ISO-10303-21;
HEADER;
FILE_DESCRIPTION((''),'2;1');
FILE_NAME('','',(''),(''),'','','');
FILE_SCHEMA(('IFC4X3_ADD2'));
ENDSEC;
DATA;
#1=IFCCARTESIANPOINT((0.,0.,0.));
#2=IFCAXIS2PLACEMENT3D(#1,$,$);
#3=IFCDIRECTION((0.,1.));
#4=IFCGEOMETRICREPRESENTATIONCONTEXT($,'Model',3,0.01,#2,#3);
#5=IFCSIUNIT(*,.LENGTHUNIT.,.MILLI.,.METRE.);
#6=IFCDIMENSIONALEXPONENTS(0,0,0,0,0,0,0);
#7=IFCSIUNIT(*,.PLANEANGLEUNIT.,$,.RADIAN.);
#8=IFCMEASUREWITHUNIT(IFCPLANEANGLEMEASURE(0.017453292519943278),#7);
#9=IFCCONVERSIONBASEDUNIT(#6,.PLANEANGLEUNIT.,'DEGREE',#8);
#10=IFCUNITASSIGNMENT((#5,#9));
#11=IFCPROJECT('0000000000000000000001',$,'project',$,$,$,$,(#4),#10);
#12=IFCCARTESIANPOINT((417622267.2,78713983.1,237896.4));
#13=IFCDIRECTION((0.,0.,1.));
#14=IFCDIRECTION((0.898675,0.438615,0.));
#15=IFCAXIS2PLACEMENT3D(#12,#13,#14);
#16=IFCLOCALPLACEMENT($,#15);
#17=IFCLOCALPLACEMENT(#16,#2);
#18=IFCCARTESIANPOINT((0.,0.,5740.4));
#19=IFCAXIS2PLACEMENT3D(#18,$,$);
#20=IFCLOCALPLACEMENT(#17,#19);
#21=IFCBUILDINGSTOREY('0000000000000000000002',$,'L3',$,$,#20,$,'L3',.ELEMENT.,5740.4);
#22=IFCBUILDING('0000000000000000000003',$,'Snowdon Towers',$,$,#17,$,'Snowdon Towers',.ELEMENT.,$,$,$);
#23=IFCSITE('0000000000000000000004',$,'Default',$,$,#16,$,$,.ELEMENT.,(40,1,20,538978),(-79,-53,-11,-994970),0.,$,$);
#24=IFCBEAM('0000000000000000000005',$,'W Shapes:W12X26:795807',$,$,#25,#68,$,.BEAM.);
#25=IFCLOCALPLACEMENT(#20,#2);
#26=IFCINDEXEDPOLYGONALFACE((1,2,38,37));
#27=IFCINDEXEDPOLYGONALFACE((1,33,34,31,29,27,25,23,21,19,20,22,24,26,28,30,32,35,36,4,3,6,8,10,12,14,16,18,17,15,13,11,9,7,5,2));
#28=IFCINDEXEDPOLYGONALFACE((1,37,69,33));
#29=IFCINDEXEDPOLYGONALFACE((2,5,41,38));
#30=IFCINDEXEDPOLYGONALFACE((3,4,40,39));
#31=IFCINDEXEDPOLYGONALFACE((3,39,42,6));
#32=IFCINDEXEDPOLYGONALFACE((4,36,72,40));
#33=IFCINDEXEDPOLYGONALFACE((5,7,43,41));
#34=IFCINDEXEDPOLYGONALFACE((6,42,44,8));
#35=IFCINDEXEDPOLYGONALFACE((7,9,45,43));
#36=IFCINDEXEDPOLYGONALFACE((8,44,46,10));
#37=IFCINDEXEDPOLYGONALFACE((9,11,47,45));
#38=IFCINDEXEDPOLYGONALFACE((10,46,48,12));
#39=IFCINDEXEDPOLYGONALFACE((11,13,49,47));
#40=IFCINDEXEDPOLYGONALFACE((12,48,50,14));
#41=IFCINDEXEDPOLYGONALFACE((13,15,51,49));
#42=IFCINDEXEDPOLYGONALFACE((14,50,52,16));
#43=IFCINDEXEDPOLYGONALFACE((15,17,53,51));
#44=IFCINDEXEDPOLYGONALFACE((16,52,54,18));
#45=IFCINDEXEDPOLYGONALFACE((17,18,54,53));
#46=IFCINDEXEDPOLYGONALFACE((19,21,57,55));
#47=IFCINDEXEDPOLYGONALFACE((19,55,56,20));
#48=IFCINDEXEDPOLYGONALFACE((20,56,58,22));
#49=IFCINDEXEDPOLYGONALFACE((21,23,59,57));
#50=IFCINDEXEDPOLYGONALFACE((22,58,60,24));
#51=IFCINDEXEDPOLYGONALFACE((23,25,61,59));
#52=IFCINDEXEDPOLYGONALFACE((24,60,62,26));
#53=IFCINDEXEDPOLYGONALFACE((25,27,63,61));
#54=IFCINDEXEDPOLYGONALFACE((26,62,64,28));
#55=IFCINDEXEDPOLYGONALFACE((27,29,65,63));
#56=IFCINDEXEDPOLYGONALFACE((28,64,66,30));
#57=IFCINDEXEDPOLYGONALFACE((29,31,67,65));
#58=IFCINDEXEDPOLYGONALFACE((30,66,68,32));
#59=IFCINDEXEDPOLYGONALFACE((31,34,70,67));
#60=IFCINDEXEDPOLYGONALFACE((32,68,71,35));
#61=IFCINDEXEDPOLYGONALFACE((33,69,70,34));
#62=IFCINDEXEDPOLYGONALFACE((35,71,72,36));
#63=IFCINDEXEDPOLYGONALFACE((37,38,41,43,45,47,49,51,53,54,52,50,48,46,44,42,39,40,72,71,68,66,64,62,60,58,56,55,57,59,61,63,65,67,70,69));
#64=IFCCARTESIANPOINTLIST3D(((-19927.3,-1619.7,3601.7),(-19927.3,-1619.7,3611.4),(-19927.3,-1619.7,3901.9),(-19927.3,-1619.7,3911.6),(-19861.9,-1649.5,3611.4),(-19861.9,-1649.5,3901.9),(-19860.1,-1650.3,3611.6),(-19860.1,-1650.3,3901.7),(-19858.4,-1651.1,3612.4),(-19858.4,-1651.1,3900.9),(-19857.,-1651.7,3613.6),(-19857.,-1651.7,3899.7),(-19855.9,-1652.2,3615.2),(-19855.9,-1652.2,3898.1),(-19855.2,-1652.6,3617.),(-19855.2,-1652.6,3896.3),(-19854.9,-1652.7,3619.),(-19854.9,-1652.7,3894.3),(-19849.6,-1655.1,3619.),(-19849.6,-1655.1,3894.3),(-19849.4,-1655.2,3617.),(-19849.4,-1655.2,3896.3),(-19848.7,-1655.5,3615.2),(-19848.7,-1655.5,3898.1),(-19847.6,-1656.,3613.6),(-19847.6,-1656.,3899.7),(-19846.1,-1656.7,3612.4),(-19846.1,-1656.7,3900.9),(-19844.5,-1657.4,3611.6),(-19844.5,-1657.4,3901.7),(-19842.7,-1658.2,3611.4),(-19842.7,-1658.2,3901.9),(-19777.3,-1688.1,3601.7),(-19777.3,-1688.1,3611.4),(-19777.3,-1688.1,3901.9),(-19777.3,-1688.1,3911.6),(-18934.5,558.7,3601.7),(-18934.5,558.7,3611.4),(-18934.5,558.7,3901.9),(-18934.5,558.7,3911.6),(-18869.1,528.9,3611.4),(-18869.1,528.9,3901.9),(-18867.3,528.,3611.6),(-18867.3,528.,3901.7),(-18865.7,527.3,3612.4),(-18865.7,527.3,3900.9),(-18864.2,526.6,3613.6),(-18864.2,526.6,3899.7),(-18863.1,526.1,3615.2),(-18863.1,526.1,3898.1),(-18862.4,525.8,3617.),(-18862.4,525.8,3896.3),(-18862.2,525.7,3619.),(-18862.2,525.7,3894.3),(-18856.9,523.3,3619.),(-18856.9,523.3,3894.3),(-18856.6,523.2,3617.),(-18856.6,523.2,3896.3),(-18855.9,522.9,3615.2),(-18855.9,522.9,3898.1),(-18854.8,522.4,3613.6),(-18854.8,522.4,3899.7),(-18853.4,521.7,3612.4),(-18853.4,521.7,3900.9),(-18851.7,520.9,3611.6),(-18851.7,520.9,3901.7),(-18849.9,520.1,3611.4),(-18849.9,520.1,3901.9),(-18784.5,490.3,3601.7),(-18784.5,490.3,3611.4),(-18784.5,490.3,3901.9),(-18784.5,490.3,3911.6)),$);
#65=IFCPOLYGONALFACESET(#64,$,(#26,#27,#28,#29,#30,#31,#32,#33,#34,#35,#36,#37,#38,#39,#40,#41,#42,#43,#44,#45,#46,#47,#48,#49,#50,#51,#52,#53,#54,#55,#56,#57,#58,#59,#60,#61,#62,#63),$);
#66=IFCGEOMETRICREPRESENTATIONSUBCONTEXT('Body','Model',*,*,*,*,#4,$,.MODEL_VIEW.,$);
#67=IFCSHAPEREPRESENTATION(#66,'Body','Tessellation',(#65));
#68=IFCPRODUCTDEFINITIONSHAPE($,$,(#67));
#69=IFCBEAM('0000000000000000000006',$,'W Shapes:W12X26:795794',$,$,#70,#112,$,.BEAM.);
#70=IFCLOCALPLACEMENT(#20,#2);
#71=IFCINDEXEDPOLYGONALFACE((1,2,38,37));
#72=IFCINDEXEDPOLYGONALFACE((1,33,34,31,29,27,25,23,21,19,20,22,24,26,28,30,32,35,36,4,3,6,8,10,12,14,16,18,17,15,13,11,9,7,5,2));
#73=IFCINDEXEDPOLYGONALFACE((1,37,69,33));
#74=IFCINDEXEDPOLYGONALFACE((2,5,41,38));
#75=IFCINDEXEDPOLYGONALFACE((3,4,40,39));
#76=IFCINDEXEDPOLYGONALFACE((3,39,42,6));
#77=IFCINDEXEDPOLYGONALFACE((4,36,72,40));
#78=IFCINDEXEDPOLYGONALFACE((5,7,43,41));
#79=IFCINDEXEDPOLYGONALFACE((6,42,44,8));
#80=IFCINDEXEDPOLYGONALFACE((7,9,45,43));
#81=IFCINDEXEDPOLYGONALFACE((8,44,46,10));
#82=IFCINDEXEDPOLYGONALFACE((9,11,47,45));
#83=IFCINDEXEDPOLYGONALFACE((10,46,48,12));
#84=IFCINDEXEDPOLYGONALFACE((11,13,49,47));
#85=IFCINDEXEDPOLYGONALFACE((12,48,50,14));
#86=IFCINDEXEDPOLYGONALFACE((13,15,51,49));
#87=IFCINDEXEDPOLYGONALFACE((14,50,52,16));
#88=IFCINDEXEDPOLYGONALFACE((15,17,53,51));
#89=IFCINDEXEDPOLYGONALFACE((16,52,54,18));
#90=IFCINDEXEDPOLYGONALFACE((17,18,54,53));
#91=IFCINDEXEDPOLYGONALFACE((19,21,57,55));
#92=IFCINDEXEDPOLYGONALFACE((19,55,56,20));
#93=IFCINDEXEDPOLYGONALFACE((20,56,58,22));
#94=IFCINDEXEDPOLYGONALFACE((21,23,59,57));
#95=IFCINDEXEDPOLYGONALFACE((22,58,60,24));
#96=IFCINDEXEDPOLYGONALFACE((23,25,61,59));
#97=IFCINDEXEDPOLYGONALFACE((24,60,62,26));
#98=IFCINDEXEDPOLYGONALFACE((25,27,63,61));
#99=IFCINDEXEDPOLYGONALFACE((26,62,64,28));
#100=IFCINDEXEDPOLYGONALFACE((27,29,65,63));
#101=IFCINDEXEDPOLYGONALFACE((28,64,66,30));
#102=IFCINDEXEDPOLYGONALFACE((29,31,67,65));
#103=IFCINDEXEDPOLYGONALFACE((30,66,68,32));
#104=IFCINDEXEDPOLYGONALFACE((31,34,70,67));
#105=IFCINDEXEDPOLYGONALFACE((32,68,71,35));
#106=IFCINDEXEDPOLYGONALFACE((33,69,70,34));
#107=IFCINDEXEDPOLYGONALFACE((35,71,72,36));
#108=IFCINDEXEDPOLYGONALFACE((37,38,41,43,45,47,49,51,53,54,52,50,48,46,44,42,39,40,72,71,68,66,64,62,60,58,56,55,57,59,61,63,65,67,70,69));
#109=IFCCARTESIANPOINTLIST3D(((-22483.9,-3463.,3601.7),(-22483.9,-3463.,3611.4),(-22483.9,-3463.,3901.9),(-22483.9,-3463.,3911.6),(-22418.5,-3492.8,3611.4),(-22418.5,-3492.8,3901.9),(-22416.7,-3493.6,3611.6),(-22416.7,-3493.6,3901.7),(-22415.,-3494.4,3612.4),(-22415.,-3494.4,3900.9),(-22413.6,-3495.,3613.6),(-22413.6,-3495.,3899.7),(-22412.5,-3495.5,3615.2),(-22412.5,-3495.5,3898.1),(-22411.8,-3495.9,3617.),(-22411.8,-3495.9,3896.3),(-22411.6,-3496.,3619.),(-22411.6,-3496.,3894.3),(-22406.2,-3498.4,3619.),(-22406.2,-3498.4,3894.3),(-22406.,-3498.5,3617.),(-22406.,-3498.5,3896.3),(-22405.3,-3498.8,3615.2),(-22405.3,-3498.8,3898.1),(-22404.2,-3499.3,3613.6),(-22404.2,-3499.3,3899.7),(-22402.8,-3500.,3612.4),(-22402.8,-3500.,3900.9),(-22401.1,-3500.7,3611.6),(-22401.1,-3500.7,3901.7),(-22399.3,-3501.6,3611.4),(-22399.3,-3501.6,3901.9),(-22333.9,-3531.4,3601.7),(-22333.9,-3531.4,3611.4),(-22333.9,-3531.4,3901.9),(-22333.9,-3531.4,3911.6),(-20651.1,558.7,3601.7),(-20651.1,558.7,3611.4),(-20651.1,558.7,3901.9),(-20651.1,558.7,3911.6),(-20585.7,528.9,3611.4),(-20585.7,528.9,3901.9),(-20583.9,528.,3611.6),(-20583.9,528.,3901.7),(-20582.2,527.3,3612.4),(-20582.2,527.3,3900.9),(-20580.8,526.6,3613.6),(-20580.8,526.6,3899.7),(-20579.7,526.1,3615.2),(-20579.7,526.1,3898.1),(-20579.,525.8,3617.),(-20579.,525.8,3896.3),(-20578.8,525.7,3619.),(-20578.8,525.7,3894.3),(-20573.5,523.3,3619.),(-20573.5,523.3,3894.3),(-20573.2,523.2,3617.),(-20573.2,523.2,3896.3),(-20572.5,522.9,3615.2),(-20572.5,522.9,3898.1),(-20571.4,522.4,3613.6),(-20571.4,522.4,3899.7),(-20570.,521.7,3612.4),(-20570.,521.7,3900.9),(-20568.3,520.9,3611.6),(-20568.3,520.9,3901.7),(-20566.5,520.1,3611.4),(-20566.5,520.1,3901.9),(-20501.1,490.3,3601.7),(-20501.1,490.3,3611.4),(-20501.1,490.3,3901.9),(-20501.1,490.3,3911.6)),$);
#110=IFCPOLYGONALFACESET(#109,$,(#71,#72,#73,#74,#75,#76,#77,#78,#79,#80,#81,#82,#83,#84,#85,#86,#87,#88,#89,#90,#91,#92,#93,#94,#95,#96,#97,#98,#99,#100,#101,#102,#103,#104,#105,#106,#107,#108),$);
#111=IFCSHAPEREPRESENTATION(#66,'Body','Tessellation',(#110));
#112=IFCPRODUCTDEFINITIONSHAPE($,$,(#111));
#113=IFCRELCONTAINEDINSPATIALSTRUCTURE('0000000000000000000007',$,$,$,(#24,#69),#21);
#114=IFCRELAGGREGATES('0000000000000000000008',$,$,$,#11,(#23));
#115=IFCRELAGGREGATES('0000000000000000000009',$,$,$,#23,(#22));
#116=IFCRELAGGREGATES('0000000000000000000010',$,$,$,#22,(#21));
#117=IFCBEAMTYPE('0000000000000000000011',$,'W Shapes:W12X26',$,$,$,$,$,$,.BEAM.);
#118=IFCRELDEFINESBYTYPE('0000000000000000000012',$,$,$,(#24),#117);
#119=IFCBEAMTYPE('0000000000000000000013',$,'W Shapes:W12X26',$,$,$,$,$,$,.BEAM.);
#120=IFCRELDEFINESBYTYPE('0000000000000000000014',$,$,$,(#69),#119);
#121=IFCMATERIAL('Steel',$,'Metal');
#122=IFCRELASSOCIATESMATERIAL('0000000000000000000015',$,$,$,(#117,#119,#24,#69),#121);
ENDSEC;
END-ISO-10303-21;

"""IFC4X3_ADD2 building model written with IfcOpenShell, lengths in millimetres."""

from ifc_helpers import new_model, entity, si_unit, converted_unit, direction, frame, frame_2d, origin, place, context, subcontext, project, spatial, polyline, circle_curve, parameter, trimmed, segment, composite_curve, outline, extrude, source, transform, mapped, material, material_profile, profile_set, profile_usage, type_object, type_shapes, element, save


model = new_model("IFC4X3_ADD2")

# Units and contexts
model_context = context("Model", 3, precision=0.01, world=origin(), true_north=direction((0.0, 1.0)))
body_context = subcontext(model_context, "Body", "Model", "MODEL_VIEW")
ifc_project = project(units=[si_unit("LENGTHUNIT", "METRE", prefix="MILLI"), converted_unit("PLANEANGLEUNIT", "DEGREE", entity("IfcPlaneAngleMeasure", 0.017453292519943278), si_unit("PLANEANGLEUNIT", "RADIAN"), dimensions=[0, 0, 0, 0, 0, 0, 0])], contexts=[model_context])

# Site, building, storey
site_placement = place(None, frame((417622267.2, 78713983.1, 237896.4), z_axis=(0.0, 0.0, 1.0), x_axis=(0.898675, 0.438615, 0.0)))
site = spatial("IfcSite", under=ifc_project, at=site_placement, Name="Default", CompositionType="ELEMENT", RefLatitude=(40, 1, 20, 538978), RefLongitude=(-79, -53, -11, -994970), RefElevation=0.0)
building_placement = place(site_placement, origin())
building = spatial("IfcBuilding", under=site, at=building_placement, Name="Snowdon Towers", LongName="Snowdon Towers", CompositionType="ELEMENT")
storey_placement = place(building_placement, frame((0.0, 0.0, 5740.4)))
storey = spatial("IfcBuildingStorey", under=building, at=storey_placement, Name="L3", LongName="L3", CompositionType="ELEMENT", Elevation=5740.4)

# Shared definitions
ifc_material_1 = material(Name="Steel", Category="Metal")

# Beams
ifc_material_profile_1 = material_profile(ifc_material_1, outline(composite_curve([segment(polyline([(-82.4, -145.3), (-82.4, -154.9)]), True, "CONTINUOUS"), segment(polyline([(-82.4, -154.9), (82.4, -154.9)]), True, "CONTINUOUS"), segment(polyline([(82.4, -154.9), (82.4, -145.3)]), True, "CONTINUOUS"), segment(polyline([(82.4, -145.3), (10.5, -145.3)]), True, "CONTINUOUS"), segment(trimmed(circle_curve(frame_2d((10.5, -137.7), x_axis=(1.0, 0.0)), 7.6), [parameter(180.0)], [parameter(270.0)], True, "PARAMETER"), False, "CONTINUOUS"), segment(polyline([(2.9, -137.7), (2.9, 137.7)]), True, "CONTINUOUS"), segment(trimmed(circle_curve(frame_2d((10.5, 137.7), x_axis=(1.0, 0.0)), 7.6), [parameter(90.0)], [parameter(180.0)], True, "PARAMETER"), False, "CONTINUOUS"), segment(polyline([(10.5, 145.3), (82.4, 145.3)]), True, "CONTINUOUS"), segment(polyline([(82.4, 145.3), (82.4, 154.9)]), True, "CONTINUOUS"), segment(polyline([(82.4, 154.9), (-82.4, 154.9)]), True, "CONTINUOUS"), segment(polyline([(-82.4, 154.9), (-82.4, 145.3)]), True, "CONTINUOUS"), segment(polyline([(-82.4, 145.3), (-10.5, 145.3)]), True, "CONTINUOUS"), segment(trimmed(circle_curve(frame_2d((-10.5, 137.7), x_axis=(1.0, 0.0)), 7.6), [parameter(360.0)], [parameter(90.0)], True, "PARAMETER"), False, "CONTINUOUS"), segment(polyline([(-2.9, 137.7), (-2.9, -137.7)]), True, "CONTINUOUS"), segment(trimmed(circle_curve(frame_2d((-10.5, -137.7), x_axis=(1.0, 0.0)), 7.6), [parameter(270.0)], [parameter(360.0)], True, "PARAMETER"), False, "CONTINUOUS"), segment(polyline([(-10.5, -145.3), (-82.4, -145.3)]), True, "CONTINUOUS")], self_intersect=False)), Name="W12X26")
ifc_profile_set_1 = profile_set([ifc_material_profile_1], Name="W12X26")
ifc_profile_usage_1 = profile_usage(ifc_profile_set_1, cardinal=8)
beam_type_1 = type_object("IfcBeamType", Name="W Shapes:W12X26", PredefinedType="BEAM", material=ifc_profile_set_1)
shared_shape_1 = source(origin(), body_context, "Body", "SweptSolid", [
    extrude(outline(composite_curve([segment(polyline([(-82.4, -145.3), (-82.4, -154.9)]), True, "CONTINUOUS"), segment(polyline([(-82.4, -154.9), (82.4, -154.9)]), True, "CONTINUOUS"), segment(polyline([(82.4, -154.9), (82.4, -145.3)]), True, "CONTINUOUS"), segment(polyline([(82.4, -145.3), (10.5, -145.3)]), True, "CONTINUOUS"), segment(trimmed(circle_curve(frame_2d((10.5, -137.7), x_axis=(0.0, -1.0)), 7.6), [parameter(270.0)], [parameter(360.0)], True, "PARAMETER"), False, "CONTINUOUS"), segment(polyline([(2.9, -137.7), (2.9, 137.7)]), True, "CONTINUOUS"), segment(trimmed(circle_curve(frame_2d((10.5, 137.7), x_axis=(-1.0, 0.0)), 7.6), [parameter(270.0)], [parameter(360.0)], True, "PARAMETER"), False, "CONTINUOUS"), segment(polyline([(10.5, 145.3), (82.4, 145.3)]), True, "CONTINUOUS"), segment(polyline([(82.4, 145.3), (82.4, 154.9)]), True, "CONTINUOUS"), segment(polyline([(82.4, 154.9), (-82.4, 154.9)]), True, "CONTINUOUS"), segment(polyline([(-82.4, 154.9), (-82.4, 145.3)]), True, "CONTINUOUS"), segment(polyline([(-82.4, 145.3), (-10.5, 145.3)]), True, "CONTINUOUS"), segment(trimmed(circle_curve(frame_2d((-10.5, 137.7), x_axis=(0.0, 1.0)), 7.6), [parameter(270.0)], [parameter(0.0)], True, "PARAMETER"), False, "CONTINUOUS"), segment(polyline([(-2.9, 137.7), (-2.9, -137.7)]), True, "CONTINUOUS"), segment(trimmed(circle_curve(frame_2d((-10.5, -137.7), x_axis=(1.0, 0.0)), 7.6), [parameter(270.0)], [parameter(0.0)], True, "PARAMETER"), False, "CONTINUOUS"), segment(polyline([(-10.5, -145.3), (-82.4, -145.3)]), True, "CONTINUOUS")], self_intersect=False)), frame((-1279.9, 0.0, 0.0), z_axis=(-1.0, 0.0, 0.0), x_axis=(0.0, -1.0, 0.0)), (0.0, 0.0, -1.0), 2393.9),
])
type_shapes(beam_type_1, [shared_shape_1])
beam_1_placement = place(storey_placement, frame((-19321.5, -489.2, 3756.7), z_axis=(0.0, 0.0, 1.0), x_axis=(0.414693, 0.909961, 0.0)))
element("IfcBeam", 1, at=beam_1_placement, inside=storey, type_object=beam_type_1, material=ifc_profile_usage_1, Name="W Shapes:W12X26:795807", PredefinedType="BEAM", context=body_context, shape_type="MappedRepresentation", body=[
    mapped(shared_shape_1, transform((0.0, 0.0, 0.0), scale=1.0)),
])
beam_type_2 = type_object("IfcBeamType", Name="W Shapes:W12X26", PredefinedType="BEAM", material=ifc_profile_set_1)
shared_shape_2 = source(origin(), body_context, "Body", "SweptSolid", [
    extrude(outline(composite_curve([segment(polyline([(-82.4, -145.3), (-82.4, -154.9)]), True, "CONTINUOUS"), segment(polyline([(-82.4, -154.9), (82.4, -154.9)]), True, "CONTINUOUS"), segment(polyline([(82.4, -154.9), (82.4, -145.3)]), True, "CONTINUOUS"), segment(polyline([(82.4, -145.3), (10.5, -145.3)]), True, "CONTINUOUS"), segment(trimmed(circle_curve(frame_2d((10.5, -137.7), x_axis=(0.0, -1.0)), 7.6), [parameter(270.0)], [parameter(360.0)], True, "PARAMETER"), False, "CONTINUOUS"), segment(polyline([(2.9, -137.7), (2.9, 137.7)]), True, "CONTINUOUS"), segment(trimmed(circle_curve(frame_2d((10.5, 137.7), x_axis=(-1.0, 0.0)), 7.6), [parameter(270.0)], [parameter(360.0)], True, "PARAMETER"), False, "CONTINUOUS"), segment(polyline([(10.5, 145.3), (82.4, 145.3)]), True, "CONTINUOUS"), segment(polyline([(82.4, 145.3), (82.4, 154.9)]), True, "CONTINUOUS"), segment(polyline([(82.4, 154.9), (-82.4, 154.9)]), True, "CONTINUOUS"), segment(polyline([(-82.4, 154.9), (-82.4, 145.3)]), True, "CONTINUOUS"), segment(polyline([(-82.4, 145.3), (-10.5, 145.3)]), True, "CONTINUOUS"), segment(trimmed(circle_curve(frame_2d((-10.5, 137.7), x_axis=(0.0, 1.0)), 7.6), [parameter(270.0)], [parameter(0.0)], True, "PARAMETER"), False, "CONTINUOUS"), segment(polyline([(-2.9, 137.7), (-2.9, -137.7)]), True, "CONTINUOUS"), segment(trimmed(circle_curve(frame_2d((-10.5, -137.7), x_axis=(1.0, 0.0)), 7.6), [parameter(270.0)], [parameter(0.0)], True, "PARAMETER"), False, "CONTINUOUS"), segment(polyline([(-10.5, -145.3), (-82.4, -145.3)]), True, "CONTINUOUS")], self_intersect=False)), frame((-2292.7, 0.0, 0.0), z_axis=(-1.0, 0.0, 0.0), x_axis=(0.0, -1.0, 0.0)), (0.0, 0.0, -1.0), 4419.6),
])
type_shapes(beam_type_2, [shared_shape_2])
beam_2_placement = place(storey_placement, frame((-21458.1, -1410.9, 3756.7), z_axis=(0.0, 0.0, 1.0), x_axis=(0.414693, 0.909961, 0.0)))
element("IfcBeam", 2, at=beam_2_placement, inside=storey, type_object=beam_type_2, material=ifc_profile_usage_1, Name="W Shapes:W12X26:795794", PredefinedType="BEAM", context=body_context, shape_type="MappedRepresentation", body=[
    mapped(shared_shape_2, transform((0.0, 0.0, 0.0), scale=1.0)),
])

save(model, "model.ifc")
